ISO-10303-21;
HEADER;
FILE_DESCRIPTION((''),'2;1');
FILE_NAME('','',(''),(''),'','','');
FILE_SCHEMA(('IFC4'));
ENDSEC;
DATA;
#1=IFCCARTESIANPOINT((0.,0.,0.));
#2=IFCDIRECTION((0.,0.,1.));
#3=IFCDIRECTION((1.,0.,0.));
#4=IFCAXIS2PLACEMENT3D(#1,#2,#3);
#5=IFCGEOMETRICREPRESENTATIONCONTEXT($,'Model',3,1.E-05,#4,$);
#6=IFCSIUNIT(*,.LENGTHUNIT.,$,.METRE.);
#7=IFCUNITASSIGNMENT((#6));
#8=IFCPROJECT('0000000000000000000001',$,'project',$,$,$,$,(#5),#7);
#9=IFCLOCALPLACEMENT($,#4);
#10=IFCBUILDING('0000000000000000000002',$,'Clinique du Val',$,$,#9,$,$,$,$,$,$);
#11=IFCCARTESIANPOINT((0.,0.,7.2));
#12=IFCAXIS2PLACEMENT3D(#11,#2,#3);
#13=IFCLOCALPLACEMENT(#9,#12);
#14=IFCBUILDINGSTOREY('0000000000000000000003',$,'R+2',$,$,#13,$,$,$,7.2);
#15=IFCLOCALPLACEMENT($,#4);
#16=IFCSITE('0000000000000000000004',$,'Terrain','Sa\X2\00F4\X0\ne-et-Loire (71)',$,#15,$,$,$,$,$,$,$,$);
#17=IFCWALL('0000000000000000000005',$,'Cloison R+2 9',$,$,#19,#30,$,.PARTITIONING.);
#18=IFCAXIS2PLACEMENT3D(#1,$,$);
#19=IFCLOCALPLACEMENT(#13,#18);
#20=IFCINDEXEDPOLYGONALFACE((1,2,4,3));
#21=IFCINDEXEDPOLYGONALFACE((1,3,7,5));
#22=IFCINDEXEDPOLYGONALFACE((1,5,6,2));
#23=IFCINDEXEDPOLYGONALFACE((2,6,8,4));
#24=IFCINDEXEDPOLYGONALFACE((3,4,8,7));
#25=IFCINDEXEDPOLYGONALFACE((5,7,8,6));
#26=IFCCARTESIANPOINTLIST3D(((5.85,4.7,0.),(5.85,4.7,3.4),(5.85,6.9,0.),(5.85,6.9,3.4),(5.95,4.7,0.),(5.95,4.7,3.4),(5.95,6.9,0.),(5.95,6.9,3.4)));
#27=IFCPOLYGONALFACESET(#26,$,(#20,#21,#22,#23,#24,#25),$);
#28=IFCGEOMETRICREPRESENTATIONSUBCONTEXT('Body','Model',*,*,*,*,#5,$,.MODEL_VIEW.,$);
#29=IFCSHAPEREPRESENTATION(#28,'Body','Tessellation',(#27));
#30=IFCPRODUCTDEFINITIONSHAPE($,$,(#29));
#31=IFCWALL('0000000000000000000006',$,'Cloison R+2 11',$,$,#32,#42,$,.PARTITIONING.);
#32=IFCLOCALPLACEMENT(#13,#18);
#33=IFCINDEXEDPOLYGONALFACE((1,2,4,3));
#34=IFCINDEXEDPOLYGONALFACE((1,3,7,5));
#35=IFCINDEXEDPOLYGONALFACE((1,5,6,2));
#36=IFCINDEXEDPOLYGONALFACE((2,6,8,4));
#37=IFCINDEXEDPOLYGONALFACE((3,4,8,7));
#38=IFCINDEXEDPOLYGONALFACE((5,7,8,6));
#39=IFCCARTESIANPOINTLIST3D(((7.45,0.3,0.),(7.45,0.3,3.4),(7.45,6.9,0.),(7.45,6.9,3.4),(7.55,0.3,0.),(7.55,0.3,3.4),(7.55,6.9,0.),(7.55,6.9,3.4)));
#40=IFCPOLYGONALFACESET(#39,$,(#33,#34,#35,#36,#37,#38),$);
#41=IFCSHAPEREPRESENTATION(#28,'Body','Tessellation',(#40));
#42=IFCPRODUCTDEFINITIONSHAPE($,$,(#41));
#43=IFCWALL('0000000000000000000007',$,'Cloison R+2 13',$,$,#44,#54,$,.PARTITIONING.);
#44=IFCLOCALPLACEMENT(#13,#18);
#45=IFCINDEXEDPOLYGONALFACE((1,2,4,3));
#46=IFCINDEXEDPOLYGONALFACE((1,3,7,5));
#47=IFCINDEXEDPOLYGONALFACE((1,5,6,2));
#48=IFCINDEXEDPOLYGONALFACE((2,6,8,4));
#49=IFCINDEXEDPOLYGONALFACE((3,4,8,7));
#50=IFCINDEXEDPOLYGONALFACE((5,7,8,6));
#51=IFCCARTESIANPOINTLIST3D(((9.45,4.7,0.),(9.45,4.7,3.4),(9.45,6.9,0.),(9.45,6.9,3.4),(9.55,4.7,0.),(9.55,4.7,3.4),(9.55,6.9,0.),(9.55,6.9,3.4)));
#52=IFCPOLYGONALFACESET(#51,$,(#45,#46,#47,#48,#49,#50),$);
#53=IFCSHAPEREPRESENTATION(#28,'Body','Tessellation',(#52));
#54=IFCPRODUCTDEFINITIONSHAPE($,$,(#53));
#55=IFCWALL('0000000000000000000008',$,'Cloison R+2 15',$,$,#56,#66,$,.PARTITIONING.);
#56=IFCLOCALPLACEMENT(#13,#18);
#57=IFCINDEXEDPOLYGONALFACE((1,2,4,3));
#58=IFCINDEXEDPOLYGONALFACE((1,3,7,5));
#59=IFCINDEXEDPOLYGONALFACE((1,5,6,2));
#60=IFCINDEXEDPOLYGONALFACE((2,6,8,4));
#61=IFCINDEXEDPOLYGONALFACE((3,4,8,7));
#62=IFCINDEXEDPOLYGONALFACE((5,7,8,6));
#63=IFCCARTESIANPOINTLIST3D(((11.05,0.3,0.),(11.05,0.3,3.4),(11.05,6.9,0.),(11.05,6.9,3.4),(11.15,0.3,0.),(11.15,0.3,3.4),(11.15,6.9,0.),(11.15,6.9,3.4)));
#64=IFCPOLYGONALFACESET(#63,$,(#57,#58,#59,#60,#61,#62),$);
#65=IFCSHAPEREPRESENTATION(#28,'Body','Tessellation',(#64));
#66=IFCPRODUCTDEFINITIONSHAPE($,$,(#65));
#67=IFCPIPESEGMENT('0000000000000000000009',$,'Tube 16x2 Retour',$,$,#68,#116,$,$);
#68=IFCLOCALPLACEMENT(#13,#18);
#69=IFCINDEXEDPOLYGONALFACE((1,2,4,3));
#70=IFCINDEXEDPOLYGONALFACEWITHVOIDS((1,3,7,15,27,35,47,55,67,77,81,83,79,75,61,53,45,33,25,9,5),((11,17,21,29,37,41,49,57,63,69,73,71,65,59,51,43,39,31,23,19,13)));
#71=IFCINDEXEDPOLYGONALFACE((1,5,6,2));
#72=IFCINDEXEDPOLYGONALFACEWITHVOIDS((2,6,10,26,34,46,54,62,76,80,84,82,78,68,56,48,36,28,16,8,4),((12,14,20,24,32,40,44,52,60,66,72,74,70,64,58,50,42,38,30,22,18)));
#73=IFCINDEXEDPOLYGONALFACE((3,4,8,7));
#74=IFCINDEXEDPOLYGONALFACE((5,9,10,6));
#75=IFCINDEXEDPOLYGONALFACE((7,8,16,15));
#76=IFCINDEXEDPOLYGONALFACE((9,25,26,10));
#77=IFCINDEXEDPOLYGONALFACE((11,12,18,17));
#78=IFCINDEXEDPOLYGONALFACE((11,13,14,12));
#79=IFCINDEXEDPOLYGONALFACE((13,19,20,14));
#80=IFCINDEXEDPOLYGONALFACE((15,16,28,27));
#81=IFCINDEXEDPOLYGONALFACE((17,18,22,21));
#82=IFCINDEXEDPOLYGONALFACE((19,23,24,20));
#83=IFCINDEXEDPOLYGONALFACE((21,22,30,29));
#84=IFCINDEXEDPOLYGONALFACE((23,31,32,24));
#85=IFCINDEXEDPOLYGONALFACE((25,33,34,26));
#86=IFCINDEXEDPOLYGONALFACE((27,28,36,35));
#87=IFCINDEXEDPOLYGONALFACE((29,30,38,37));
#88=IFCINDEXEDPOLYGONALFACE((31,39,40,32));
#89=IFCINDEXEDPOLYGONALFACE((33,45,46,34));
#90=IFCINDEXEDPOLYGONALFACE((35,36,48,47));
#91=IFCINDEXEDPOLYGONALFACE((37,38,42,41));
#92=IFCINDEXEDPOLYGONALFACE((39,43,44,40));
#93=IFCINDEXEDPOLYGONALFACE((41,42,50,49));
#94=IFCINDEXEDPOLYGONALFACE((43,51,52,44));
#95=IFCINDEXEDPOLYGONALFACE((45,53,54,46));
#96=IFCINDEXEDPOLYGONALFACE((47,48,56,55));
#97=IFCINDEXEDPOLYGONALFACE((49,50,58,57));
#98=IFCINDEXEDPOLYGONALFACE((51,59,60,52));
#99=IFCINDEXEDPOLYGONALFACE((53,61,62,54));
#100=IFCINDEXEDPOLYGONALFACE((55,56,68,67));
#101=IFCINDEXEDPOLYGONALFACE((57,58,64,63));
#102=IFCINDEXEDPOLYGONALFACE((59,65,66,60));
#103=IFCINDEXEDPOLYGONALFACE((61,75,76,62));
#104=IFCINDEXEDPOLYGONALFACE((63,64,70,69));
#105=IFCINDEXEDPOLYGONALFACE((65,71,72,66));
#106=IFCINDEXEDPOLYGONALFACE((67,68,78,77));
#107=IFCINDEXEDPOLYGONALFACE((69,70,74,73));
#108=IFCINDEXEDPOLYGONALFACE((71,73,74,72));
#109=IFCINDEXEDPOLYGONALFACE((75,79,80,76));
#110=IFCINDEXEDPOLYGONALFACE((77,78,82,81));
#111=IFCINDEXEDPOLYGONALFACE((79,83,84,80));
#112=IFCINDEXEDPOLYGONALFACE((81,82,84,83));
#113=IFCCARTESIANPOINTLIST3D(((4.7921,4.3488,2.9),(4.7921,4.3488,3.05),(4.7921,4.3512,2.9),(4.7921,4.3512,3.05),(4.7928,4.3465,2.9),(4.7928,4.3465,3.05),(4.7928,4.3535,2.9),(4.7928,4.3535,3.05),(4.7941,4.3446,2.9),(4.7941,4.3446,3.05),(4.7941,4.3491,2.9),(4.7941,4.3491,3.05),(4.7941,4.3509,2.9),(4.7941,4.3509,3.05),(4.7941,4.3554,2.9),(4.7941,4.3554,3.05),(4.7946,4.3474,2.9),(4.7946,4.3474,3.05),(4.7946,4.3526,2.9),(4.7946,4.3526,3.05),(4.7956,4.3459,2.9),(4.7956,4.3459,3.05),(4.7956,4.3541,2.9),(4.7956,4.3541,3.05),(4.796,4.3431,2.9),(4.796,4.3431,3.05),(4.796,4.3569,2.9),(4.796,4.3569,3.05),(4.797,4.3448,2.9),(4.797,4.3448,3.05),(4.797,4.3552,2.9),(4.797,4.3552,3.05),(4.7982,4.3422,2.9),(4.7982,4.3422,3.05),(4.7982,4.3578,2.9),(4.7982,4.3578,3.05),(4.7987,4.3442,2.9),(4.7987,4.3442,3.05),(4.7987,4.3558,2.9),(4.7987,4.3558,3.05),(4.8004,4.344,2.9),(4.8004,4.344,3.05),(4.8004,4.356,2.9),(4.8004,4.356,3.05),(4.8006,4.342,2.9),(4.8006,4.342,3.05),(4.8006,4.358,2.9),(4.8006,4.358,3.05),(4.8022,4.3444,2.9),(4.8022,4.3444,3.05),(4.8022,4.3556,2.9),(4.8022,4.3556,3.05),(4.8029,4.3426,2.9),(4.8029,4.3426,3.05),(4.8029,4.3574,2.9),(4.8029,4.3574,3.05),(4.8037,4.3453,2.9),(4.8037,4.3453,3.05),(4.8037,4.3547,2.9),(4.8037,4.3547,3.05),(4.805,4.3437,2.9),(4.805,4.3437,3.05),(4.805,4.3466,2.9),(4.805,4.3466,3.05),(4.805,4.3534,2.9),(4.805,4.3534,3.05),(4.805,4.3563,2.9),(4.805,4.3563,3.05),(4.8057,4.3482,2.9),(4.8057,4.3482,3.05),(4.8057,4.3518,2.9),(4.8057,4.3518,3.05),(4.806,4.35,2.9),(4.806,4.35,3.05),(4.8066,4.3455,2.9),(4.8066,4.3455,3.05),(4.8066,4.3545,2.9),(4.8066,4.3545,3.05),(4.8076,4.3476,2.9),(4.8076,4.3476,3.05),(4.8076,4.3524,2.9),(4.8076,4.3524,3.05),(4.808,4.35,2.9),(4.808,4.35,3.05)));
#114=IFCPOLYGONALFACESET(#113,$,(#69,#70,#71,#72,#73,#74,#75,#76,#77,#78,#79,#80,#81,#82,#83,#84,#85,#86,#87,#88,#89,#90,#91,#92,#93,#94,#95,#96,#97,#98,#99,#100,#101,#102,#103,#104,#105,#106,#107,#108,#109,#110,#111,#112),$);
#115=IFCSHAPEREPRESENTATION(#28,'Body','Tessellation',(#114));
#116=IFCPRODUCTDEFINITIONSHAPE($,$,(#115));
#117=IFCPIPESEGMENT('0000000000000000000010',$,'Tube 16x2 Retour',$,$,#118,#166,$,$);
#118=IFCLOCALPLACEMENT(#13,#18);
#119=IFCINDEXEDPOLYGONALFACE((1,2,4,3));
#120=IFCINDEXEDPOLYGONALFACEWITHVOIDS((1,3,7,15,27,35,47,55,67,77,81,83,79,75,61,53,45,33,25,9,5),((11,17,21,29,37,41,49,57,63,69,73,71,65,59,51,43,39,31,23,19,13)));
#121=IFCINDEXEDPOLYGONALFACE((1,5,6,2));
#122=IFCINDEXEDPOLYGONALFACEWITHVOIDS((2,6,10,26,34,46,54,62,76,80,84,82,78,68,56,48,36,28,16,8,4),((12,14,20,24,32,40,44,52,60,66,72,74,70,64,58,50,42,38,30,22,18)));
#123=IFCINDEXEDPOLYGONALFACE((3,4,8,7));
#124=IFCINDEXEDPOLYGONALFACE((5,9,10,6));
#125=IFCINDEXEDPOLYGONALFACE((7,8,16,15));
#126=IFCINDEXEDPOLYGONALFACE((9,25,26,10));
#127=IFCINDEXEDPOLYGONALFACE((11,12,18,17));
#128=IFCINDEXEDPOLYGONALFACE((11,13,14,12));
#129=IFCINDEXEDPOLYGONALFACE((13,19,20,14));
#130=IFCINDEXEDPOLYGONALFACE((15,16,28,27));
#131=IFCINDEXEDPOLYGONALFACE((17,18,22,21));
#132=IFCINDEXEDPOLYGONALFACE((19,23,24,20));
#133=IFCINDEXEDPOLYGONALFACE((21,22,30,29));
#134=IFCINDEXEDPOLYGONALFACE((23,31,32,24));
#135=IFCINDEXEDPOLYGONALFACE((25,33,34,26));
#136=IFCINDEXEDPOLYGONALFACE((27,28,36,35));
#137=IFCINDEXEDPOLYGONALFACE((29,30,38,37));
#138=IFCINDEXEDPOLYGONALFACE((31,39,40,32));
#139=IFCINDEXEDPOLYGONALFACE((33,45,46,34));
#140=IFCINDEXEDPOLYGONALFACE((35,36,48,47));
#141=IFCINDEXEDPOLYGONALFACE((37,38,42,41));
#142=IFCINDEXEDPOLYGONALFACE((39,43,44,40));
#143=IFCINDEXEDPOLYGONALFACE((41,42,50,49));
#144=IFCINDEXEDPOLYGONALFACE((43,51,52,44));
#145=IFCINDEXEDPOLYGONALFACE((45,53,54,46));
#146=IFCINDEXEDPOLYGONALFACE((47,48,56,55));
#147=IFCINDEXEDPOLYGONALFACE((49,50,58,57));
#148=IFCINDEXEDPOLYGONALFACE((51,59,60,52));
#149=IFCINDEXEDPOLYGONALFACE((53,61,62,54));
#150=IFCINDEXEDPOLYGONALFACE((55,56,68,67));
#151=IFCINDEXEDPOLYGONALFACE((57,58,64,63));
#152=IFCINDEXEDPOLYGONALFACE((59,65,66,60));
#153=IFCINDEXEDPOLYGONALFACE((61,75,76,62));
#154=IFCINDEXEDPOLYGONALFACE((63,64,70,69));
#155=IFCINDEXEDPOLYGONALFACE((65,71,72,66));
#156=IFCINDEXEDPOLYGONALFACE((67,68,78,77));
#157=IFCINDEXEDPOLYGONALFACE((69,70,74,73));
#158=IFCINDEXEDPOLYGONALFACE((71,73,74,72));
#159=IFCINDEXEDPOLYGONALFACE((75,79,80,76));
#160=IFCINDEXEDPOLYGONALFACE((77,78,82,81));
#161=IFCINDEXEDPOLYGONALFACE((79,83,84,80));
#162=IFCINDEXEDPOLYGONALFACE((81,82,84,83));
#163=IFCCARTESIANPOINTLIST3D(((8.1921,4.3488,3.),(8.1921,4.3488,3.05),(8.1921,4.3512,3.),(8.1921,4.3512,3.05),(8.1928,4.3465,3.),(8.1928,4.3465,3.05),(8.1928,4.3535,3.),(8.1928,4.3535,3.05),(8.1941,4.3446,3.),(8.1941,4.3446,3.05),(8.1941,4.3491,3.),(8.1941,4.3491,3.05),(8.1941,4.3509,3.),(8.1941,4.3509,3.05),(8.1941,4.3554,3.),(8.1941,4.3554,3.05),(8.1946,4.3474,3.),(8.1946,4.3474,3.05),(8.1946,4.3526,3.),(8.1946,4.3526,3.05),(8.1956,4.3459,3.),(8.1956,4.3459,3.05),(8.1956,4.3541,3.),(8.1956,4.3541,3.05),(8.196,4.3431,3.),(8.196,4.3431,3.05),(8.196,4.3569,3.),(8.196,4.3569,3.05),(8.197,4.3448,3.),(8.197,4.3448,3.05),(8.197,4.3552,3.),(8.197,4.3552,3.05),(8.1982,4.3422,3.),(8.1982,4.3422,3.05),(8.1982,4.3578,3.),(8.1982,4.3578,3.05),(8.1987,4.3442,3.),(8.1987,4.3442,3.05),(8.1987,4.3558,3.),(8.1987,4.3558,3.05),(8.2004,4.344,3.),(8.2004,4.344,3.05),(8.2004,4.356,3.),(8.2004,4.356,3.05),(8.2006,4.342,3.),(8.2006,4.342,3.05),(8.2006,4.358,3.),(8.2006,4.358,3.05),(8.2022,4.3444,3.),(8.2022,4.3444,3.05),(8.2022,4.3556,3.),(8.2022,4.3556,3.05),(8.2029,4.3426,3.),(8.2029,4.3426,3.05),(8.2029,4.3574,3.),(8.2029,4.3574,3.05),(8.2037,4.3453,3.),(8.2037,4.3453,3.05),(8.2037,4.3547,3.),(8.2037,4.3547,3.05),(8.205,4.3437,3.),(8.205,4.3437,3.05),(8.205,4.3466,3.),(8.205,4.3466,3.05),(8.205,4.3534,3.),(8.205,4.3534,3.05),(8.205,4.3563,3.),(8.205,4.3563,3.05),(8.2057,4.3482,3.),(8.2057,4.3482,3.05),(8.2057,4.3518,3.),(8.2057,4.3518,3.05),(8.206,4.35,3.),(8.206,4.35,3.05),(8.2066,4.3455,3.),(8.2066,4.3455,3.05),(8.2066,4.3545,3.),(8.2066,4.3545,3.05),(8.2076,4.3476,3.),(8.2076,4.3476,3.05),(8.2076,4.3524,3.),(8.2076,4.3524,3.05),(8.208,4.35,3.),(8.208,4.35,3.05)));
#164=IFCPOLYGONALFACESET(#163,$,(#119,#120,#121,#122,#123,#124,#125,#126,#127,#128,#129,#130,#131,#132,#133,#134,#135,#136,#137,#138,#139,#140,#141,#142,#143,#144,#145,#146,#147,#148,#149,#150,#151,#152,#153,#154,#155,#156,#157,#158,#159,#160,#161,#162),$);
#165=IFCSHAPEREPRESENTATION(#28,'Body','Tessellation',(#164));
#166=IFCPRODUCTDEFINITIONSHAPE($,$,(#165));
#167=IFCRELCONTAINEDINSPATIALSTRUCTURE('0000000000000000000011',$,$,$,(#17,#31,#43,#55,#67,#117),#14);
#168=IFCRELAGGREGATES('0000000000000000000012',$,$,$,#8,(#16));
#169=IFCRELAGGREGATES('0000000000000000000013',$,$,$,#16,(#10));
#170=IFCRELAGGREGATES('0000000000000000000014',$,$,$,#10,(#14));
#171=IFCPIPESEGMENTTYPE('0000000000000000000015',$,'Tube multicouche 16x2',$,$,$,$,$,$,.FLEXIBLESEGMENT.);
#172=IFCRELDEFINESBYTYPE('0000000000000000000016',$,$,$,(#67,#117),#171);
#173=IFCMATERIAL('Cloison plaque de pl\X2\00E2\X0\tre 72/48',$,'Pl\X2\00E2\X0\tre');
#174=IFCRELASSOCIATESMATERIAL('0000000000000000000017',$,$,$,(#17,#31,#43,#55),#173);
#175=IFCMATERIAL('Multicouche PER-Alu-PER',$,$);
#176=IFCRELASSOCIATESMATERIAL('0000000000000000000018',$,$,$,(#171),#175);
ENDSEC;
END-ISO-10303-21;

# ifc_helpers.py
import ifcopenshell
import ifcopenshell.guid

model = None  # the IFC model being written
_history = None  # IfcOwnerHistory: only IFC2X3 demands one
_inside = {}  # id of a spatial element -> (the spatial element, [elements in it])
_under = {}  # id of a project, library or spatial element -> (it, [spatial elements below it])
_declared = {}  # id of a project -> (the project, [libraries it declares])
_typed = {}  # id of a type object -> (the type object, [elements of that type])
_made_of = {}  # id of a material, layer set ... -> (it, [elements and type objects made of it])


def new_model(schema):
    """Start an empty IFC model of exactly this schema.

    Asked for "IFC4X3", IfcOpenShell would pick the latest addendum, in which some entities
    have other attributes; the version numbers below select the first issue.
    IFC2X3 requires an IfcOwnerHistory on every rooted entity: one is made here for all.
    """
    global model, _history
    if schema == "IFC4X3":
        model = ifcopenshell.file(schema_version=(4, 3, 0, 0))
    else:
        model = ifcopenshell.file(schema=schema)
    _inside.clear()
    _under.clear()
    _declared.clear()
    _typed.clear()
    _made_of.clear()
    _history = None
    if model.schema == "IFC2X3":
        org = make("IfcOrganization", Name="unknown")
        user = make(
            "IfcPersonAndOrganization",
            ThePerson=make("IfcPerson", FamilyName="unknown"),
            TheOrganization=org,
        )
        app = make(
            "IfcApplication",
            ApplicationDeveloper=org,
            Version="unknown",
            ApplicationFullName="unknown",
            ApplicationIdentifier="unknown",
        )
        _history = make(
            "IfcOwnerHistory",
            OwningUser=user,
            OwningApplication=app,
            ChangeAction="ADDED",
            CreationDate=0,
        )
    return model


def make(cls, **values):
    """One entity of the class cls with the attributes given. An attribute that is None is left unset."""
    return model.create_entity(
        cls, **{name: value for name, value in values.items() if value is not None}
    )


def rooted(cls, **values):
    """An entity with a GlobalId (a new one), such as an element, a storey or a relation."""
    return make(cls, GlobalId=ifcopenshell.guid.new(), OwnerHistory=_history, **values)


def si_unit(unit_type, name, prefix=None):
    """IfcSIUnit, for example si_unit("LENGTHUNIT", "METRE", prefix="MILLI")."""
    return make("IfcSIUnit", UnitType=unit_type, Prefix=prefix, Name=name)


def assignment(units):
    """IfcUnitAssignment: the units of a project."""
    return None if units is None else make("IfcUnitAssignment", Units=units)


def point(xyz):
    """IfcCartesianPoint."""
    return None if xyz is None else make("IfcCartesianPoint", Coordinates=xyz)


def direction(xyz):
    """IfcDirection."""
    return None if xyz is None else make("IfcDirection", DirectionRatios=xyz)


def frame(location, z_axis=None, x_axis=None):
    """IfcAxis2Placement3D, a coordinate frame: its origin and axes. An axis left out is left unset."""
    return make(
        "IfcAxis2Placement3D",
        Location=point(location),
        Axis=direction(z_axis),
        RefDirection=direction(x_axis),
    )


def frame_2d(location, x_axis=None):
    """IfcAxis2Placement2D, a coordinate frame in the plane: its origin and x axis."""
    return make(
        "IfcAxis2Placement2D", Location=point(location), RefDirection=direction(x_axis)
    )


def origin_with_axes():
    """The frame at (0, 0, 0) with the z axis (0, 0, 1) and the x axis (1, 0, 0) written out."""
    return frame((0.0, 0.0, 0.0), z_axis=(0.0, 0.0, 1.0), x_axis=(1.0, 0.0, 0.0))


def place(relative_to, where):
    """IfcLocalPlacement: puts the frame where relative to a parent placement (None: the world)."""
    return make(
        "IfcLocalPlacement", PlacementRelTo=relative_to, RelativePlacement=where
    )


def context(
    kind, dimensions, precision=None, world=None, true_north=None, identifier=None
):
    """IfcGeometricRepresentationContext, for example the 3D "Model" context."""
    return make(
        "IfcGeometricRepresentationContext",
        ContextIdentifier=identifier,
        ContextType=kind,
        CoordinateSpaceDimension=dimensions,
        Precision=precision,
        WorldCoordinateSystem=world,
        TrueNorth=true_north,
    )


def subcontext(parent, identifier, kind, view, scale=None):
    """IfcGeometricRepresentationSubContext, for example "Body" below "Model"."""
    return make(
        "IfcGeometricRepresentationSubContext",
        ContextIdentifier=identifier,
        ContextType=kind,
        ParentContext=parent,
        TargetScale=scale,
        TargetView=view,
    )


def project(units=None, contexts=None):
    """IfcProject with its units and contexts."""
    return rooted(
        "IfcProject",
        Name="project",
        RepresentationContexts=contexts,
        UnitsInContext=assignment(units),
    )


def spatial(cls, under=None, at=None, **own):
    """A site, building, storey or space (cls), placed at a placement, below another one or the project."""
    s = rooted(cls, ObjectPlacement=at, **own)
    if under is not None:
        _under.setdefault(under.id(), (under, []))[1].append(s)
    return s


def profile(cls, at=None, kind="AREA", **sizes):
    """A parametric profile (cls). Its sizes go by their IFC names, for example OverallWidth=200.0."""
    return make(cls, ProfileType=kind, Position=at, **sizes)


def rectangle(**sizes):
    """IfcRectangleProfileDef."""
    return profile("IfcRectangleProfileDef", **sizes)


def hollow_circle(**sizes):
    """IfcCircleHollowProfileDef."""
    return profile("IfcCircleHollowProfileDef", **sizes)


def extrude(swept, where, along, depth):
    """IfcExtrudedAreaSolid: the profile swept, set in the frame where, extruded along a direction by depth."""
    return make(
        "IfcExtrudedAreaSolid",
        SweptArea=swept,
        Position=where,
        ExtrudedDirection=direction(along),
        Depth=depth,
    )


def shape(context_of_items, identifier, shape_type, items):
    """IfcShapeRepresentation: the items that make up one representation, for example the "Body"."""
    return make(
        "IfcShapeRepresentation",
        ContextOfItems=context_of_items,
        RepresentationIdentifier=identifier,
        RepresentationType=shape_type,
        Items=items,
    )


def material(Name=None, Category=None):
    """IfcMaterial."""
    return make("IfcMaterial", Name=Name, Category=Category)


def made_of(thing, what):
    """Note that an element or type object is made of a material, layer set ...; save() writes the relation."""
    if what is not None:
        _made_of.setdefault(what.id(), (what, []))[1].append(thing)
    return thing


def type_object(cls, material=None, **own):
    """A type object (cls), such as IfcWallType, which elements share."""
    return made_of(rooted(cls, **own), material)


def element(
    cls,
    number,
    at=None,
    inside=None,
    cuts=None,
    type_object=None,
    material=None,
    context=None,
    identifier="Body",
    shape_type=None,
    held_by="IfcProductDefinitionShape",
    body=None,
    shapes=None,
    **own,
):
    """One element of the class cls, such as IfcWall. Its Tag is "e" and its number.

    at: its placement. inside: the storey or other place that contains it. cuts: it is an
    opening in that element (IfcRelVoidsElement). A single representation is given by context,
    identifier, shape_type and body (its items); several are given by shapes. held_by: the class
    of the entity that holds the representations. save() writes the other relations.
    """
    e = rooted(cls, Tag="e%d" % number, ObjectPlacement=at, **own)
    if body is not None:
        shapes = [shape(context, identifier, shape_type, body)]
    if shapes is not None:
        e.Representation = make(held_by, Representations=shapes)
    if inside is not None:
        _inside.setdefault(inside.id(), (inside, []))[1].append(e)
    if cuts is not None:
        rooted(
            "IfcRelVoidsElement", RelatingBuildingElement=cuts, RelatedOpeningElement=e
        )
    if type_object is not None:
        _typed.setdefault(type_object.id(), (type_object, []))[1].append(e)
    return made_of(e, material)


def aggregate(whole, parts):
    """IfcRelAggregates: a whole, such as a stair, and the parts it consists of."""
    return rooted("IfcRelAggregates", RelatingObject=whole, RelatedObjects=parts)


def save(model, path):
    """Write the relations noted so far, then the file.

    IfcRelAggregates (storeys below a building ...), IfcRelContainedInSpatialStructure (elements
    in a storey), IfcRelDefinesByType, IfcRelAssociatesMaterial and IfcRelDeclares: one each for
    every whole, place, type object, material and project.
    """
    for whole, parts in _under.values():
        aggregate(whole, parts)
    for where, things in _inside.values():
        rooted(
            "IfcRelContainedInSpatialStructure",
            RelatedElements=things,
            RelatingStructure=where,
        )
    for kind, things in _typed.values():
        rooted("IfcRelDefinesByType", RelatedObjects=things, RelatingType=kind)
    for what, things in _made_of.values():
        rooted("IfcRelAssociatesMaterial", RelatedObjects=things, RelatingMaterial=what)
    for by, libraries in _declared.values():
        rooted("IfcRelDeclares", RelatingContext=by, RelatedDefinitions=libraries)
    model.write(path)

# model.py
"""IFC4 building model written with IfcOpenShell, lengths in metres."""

from ifc_helpers import new_model, si_unit, frame, frame_2d, origin_with_axes, place, context, subcontext, project, spatial, rectangle, hollow_circle, extrude, material, type_object, element, save


model = new_model("IFC4")

# Units and contexts
model_context = context("Model", 3, precision=1e-05, world=origin_with_axes())
body_context = subcontext(model_context, "Body", "Model", "MODEL_VIEW")
ifc_project = project(units=[si_unit("LENGTHUNIT", "METRE")], contexts=[model_context])

# Site, building, storey
site_placement = place(None, origin_with_axes())
site = spatial("IfcSite", under=ifc_project, at=site_placement, Name="Terrain", Description="Saône-et-Loire (71)")
building_placement = place(None, origin_with_axes())
building = spatial("IfcBuilding", under=site, at=building_placement, Name="Clinique du Val")
storey_placement = place(building_placement, frame((0.0, 0.0, 7.2), z_axis=(0.0, 0.0, 1.0), x_axis=(1.0, 0.0, 0.0)))
storey = spatial("IfcBuildingStorey", under=building, at=storey_placement, Name="R+2", Elevation=7.2)

# Walls
ifc_material_1 = material(Name="Cloison plaque de plâtre 72/48", Category="Plâtre")
wall_1_placement = place(storey_placement, frame((5.85, 4.7, 0.0), z_axis=(0.0, 0.0, 1.0), x_axis=(1.0, 0.0, 0.0)))
element("IfcWall", 1, at=wall_1_placement, inside=storey, material=ifc_material_1, Name="Cloison R+2 9", PredefinedType="PARTITIONING", context=body_context, shape_type="SweptSolid", body=[
    extrude(rectangle(XDim=0.1, YDim=2.2, at=frame_2d((0.05, 1.1))), origin_with_axes(), (0.0, 0.0, 1.0), 3.4),
])
wall_2_placement = place(storey_placement, frame((7.45, 0.3, 0.0), z_axis=(0.0, 0.0, 1.0), x_axis=(1.0, 0.0, 0.0)))
element("IfcWall", 2, at=wall_2_placement, inside=storey, material=ifc_material_1, Name="Cloison R+2 11", PredefinedType="PARTITIONING", context=body_context, shape_type="SweptSolid", body=[
    extrude(rectangle(XDim=0.1, YDim=6.6, at=frame_2d((0.05, 3.3))), origin_with_axes(), (0.0, 0.0, 1.0), 3.4),
])
wall_3_placement = place(storey_placement, frame((9.45, 4.7, 0.0), z_axis=(0.0, 0.0, 1.0), x_axis=(1.0, 0.0, 0.0)))
element("IfcWall", 3, at=wall_3_placement, inside=storey, material=ifc_material_1, Name="Cloison R+2 13", PredefinedType="PARTITIONING", context=body_context, shape_type="SweptSolid", body=[
    extrude(rectangle(XDim=0.1, YDim=2.2, at=frame_2d((0.05, 1.1))), origin_with_axes(), (0.0, 0.0, 1.0), 3.4),
])
wall_4_placement = place(storey_placement, frame((11.05, 0.3, 0.0), z_axis=(0.0, 0.0, 1.0), x_axis=(1.0, 0.0, 0.0)))
element("IfcWall", 4, at=wall_4_placement, inside=storey, material=ifc_material_1, Name="Cloison R+2 15", PredefinedType="PARTITIONING", context=body_context, shape_type="SweptSolid", body=[
    extrude(rectangle(XDim=0.1, YDim=6.6, at=frame_2d((0.05, 3.3))), origin_with_axes(), (0.0, 0.0, 1.0), 3.4),
])

# Pipe segments
ifc_material_2 = material(Name="Multicouche PER-Alu-PER")
pipe_segment_type = type_object("IfcPipeSegmentType", Name="Tube multicouche 16x2", PredefinedType="FLEXIBLESEGMENT", material=ifc_material_2)
pipe_segment_1_placement = place(storey_placement, frame((4.8, 4.35, 2.9), z_axis=(0.0, 0.0, 1.0), x_axis=(1.0, 0.0, 0.0)))
element("IfcPipeSegment", 5, at=pipe_segment_1_placement, inside=storey, type_object=pipe_segment_type, Name="Tube 16x2 Retour", context=body_context, shape_type="SweptSolid", body=[
    extrude(hollow_circle(Radius=0.008, WallThickness=0.002), origin_with_axes(), (0.0, 0.0, 1.0), 0.15),
])
pipe_segment_2_placement = place(storey_placement, frame((8.2, 4.35, 3.0), z_axis=(0.0, 0.0, 1.0), x_axis=(1.0, 0.0, 0.0)))
element("IfcPipeSegment", 6, at=pipe_segment_2_placement, inside=storey, type_object=pipe_segment_type, Name="Tube 16x2 Retour", context=body_context, shape_type="SweptSolid", body=[
    extrude(hollow_circle(Radius=0.008, WallThickness=0.002), origin_with_axes(), (0.0, 0.0, 1.0), 0.05),
])

save(model, "model.ifc")
